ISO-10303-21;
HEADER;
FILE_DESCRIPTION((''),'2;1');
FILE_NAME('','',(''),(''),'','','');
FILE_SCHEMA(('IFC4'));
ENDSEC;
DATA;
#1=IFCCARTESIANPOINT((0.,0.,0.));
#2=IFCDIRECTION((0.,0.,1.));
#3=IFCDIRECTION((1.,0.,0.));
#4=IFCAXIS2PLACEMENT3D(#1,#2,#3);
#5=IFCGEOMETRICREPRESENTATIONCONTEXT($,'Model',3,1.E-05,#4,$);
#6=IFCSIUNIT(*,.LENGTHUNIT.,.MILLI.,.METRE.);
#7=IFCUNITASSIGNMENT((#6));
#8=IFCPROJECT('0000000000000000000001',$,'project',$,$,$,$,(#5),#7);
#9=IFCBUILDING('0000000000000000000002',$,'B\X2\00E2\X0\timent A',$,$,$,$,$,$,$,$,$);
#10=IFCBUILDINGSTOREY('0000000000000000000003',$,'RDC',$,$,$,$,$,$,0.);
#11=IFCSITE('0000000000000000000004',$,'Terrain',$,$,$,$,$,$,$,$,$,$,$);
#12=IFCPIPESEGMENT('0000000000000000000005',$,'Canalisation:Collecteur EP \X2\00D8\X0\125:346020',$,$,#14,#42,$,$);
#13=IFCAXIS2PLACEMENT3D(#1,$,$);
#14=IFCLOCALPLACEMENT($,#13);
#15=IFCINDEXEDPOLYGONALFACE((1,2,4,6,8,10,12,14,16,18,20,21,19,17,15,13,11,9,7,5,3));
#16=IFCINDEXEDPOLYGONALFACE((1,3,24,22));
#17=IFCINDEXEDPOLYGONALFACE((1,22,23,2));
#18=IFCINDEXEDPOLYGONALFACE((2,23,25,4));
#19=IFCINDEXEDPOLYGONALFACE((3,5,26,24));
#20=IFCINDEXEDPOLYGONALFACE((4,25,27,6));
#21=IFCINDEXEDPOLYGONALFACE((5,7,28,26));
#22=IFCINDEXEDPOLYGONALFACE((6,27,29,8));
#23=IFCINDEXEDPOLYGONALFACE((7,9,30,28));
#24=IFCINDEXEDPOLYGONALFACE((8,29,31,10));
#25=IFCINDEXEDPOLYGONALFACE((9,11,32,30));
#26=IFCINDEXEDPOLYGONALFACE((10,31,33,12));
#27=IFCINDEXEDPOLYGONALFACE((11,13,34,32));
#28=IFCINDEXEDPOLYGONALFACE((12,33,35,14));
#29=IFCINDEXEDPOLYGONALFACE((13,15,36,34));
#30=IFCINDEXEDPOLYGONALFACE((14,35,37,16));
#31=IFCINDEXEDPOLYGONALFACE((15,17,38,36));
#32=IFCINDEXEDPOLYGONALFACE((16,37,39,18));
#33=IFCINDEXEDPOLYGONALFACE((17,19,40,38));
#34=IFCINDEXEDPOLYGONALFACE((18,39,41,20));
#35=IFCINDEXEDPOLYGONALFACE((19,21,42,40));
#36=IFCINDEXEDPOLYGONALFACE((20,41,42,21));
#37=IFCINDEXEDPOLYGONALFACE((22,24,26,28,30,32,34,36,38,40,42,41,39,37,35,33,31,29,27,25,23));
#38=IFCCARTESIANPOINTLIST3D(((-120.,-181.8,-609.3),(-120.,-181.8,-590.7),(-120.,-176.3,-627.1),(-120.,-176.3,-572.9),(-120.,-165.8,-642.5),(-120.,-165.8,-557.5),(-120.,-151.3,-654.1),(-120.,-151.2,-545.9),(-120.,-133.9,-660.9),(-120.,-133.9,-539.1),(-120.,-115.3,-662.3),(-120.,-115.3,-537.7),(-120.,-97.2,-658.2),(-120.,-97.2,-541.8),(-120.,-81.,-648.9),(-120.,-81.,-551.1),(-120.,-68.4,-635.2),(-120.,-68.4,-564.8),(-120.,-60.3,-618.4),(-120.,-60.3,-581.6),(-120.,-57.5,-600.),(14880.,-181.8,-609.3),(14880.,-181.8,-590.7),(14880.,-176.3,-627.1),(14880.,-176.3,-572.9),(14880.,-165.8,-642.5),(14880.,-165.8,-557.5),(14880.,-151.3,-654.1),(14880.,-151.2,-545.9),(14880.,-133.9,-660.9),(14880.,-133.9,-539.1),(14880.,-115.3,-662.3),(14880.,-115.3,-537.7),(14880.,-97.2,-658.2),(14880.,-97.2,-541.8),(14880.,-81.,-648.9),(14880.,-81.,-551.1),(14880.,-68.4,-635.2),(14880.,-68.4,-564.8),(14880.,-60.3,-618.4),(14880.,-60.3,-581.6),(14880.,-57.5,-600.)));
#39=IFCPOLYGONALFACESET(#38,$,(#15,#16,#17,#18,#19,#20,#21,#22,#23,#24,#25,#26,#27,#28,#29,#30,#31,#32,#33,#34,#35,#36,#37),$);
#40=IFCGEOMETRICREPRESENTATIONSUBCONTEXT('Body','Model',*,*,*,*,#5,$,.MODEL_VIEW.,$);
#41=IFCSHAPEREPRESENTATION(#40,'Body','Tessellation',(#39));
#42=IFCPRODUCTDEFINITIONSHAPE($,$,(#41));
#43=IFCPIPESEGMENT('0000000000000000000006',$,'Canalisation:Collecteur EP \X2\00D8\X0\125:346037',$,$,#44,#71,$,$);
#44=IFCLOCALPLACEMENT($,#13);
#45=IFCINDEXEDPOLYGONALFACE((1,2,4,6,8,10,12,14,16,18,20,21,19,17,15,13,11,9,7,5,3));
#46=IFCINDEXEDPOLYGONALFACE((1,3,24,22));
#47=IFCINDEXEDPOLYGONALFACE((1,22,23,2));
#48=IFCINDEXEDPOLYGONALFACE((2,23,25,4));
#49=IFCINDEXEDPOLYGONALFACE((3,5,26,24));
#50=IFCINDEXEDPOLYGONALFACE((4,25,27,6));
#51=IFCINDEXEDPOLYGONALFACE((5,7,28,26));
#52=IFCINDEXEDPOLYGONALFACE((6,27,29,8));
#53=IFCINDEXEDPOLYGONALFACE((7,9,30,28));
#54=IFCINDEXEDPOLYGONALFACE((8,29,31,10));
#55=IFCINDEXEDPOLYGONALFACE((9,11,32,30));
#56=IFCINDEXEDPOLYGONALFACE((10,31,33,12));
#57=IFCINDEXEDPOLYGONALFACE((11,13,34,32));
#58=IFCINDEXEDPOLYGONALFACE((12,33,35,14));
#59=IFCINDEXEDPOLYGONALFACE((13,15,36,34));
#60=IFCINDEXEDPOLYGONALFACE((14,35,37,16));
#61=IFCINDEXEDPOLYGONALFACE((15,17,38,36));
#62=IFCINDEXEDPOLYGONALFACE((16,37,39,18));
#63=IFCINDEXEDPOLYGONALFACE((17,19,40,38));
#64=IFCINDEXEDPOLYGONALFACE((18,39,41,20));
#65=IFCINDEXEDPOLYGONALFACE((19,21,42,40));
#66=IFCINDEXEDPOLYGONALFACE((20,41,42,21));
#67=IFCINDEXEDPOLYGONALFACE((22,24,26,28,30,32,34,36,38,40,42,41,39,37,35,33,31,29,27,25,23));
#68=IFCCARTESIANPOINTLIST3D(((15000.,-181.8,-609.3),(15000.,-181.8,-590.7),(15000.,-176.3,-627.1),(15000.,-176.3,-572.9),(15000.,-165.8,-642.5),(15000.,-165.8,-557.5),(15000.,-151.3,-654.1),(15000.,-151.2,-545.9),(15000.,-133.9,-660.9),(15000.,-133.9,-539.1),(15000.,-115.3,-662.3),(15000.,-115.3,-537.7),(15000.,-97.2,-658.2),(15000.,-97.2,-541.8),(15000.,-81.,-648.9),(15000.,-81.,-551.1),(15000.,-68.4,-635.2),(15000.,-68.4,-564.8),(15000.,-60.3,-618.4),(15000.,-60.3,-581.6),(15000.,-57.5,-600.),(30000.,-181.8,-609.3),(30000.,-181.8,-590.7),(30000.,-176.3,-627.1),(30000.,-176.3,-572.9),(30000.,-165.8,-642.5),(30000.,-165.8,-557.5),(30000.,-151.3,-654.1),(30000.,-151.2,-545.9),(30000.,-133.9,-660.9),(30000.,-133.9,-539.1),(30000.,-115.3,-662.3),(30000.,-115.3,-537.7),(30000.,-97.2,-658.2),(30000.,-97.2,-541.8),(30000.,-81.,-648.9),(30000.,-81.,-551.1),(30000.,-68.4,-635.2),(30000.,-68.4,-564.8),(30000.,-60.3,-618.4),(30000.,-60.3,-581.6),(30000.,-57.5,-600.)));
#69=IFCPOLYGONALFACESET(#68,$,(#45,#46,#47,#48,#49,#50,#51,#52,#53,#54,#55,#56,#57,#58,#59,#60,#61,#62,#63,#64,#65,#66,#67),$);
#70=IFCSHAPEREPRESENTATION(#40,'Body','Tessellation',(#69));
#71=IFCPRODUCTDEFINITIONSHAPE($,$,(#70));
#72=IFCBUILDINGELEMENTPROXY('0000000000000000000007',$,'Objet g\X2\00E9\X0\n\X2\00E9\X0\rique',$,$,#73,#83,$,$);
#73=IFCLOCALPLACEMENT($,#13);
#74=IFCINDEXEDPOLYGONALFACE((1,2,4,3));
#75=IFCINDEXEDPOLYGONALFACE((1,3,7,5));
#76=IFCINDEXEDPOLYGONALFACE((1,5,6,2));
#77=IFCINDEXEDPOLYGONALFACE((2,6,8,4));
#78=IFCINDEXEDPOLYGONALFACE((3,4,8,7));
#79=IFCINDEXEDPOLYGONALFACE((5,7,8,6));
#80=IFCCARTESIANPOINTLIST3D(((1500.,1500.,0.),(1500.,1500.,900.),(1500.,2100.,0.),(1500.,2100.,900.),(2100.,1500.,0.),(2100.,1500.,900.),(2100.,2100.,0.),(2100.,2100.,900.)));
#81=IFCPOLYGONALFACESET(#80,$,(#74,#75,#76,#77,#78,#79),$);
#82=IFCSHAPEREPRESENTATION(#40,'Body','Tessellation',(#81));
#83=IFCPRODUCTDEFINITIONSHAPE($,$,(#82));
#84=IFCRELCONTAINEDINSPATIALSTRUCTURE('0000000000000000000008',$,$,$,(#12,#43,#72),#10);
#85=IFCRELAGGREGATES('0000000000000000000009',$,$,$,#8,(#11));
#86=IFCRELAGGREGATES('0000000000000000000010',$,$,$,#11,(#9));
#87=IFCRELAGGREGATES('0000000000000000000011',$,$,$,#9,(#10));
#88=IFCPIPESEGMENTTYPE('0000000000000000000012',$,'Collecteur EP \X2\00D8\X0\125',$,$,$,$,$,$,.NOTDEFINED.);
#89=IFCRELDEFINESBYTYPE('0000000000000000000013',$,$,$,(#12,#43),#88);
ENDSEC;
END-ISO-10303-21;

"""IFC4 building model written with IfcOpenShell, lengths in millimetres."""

from ifc_helpers import new_model, si_unit, frame, frame_2d, origin_with_axes, origin_2d, place, context, subcontext, project, spatial, rectangle, circle, extrude, type_object, element, save


model = new_model("IFC4")

# Units and contexts
model_context = context("Model", 3, precision=1e-05, world=origin_with_axes())
body_context = subcontext(model_context, "Body", "Model", "MODEL_VIEW")
ifc_project = project(units=[si_unit("LENGTHUNIT", "METRE", prefix="MILLI")], contexts=[model_context])

# Site, building, storey
site = spatial("IfcSite", under=ifc_project, Name="Terrain")
building = spatial("IfcBuilding", under=site, Name="Bâtiment A")
storey = spatial("IfcBuildingStorey", under=building, Name="RDC", Elevation=0.0)

# Pipe segments
pipe_segment_type_1 = type_object("IfcPipeSegmentType", Name="Collecteur EP Ø125", PredefinedType="NOTDEFINED")
pipe_segment_1_placement = place(None, origin_with_axes())
element("IfcPipeSegment", 1, at=pipe_segment_1_placement, inside=storey, type_object=pipe_segment_type_1, Name="Canalisation:Collecteur EP Ø125:346020", context=body_context, shape_type="SweptSolid", body=[
    extrude(circle(Radius=62.5, at=origin_2d()), frame((-120.0, -120.0, -600.0), z_axis=(1.0, 0.0, 0.0), x_axis=(0.0, 1.0, 0.0)), (0.0, 0.0, 1.0), 15000.0),
])
pipe_segment_2_placement = place(None, origin_with_axes())
element("IfcPipeSegment", 2, at=pipe_segment_2_placement, inside=storey, type_object=pipe_segment_type_1, Name="Canalisation:Collecteur EP Ø125:346037", context=body_context, shape_type="SweptSolid", body=[
    extrude(circle(Radius=62.5, at=origin_2d()), frame((15000.0, -120.0, -600.0), z_axis=(1.0, 0.0, 0.0), x_axis=(0.0, 1.0, 0.0)), (0.0, 0.0, 1.0), 15000.0),
])

# Building element proxy
proxy_placement = place(None, origin_with_axes())
element("IfcBuildingElementProxy", 3, at=proxy_placement, inside=storey, Name="Objet générique", context=body_context, shape_type="SweptSolid", body=[
    extrude(rectangle(XDim=600.0, YDim=600.0, at=frame_2d((1800.0, 1800.0))), origin_with_axes(), (0.0, 0.0, 1.0), 900.0),
])

save(model, "model.ifc")
